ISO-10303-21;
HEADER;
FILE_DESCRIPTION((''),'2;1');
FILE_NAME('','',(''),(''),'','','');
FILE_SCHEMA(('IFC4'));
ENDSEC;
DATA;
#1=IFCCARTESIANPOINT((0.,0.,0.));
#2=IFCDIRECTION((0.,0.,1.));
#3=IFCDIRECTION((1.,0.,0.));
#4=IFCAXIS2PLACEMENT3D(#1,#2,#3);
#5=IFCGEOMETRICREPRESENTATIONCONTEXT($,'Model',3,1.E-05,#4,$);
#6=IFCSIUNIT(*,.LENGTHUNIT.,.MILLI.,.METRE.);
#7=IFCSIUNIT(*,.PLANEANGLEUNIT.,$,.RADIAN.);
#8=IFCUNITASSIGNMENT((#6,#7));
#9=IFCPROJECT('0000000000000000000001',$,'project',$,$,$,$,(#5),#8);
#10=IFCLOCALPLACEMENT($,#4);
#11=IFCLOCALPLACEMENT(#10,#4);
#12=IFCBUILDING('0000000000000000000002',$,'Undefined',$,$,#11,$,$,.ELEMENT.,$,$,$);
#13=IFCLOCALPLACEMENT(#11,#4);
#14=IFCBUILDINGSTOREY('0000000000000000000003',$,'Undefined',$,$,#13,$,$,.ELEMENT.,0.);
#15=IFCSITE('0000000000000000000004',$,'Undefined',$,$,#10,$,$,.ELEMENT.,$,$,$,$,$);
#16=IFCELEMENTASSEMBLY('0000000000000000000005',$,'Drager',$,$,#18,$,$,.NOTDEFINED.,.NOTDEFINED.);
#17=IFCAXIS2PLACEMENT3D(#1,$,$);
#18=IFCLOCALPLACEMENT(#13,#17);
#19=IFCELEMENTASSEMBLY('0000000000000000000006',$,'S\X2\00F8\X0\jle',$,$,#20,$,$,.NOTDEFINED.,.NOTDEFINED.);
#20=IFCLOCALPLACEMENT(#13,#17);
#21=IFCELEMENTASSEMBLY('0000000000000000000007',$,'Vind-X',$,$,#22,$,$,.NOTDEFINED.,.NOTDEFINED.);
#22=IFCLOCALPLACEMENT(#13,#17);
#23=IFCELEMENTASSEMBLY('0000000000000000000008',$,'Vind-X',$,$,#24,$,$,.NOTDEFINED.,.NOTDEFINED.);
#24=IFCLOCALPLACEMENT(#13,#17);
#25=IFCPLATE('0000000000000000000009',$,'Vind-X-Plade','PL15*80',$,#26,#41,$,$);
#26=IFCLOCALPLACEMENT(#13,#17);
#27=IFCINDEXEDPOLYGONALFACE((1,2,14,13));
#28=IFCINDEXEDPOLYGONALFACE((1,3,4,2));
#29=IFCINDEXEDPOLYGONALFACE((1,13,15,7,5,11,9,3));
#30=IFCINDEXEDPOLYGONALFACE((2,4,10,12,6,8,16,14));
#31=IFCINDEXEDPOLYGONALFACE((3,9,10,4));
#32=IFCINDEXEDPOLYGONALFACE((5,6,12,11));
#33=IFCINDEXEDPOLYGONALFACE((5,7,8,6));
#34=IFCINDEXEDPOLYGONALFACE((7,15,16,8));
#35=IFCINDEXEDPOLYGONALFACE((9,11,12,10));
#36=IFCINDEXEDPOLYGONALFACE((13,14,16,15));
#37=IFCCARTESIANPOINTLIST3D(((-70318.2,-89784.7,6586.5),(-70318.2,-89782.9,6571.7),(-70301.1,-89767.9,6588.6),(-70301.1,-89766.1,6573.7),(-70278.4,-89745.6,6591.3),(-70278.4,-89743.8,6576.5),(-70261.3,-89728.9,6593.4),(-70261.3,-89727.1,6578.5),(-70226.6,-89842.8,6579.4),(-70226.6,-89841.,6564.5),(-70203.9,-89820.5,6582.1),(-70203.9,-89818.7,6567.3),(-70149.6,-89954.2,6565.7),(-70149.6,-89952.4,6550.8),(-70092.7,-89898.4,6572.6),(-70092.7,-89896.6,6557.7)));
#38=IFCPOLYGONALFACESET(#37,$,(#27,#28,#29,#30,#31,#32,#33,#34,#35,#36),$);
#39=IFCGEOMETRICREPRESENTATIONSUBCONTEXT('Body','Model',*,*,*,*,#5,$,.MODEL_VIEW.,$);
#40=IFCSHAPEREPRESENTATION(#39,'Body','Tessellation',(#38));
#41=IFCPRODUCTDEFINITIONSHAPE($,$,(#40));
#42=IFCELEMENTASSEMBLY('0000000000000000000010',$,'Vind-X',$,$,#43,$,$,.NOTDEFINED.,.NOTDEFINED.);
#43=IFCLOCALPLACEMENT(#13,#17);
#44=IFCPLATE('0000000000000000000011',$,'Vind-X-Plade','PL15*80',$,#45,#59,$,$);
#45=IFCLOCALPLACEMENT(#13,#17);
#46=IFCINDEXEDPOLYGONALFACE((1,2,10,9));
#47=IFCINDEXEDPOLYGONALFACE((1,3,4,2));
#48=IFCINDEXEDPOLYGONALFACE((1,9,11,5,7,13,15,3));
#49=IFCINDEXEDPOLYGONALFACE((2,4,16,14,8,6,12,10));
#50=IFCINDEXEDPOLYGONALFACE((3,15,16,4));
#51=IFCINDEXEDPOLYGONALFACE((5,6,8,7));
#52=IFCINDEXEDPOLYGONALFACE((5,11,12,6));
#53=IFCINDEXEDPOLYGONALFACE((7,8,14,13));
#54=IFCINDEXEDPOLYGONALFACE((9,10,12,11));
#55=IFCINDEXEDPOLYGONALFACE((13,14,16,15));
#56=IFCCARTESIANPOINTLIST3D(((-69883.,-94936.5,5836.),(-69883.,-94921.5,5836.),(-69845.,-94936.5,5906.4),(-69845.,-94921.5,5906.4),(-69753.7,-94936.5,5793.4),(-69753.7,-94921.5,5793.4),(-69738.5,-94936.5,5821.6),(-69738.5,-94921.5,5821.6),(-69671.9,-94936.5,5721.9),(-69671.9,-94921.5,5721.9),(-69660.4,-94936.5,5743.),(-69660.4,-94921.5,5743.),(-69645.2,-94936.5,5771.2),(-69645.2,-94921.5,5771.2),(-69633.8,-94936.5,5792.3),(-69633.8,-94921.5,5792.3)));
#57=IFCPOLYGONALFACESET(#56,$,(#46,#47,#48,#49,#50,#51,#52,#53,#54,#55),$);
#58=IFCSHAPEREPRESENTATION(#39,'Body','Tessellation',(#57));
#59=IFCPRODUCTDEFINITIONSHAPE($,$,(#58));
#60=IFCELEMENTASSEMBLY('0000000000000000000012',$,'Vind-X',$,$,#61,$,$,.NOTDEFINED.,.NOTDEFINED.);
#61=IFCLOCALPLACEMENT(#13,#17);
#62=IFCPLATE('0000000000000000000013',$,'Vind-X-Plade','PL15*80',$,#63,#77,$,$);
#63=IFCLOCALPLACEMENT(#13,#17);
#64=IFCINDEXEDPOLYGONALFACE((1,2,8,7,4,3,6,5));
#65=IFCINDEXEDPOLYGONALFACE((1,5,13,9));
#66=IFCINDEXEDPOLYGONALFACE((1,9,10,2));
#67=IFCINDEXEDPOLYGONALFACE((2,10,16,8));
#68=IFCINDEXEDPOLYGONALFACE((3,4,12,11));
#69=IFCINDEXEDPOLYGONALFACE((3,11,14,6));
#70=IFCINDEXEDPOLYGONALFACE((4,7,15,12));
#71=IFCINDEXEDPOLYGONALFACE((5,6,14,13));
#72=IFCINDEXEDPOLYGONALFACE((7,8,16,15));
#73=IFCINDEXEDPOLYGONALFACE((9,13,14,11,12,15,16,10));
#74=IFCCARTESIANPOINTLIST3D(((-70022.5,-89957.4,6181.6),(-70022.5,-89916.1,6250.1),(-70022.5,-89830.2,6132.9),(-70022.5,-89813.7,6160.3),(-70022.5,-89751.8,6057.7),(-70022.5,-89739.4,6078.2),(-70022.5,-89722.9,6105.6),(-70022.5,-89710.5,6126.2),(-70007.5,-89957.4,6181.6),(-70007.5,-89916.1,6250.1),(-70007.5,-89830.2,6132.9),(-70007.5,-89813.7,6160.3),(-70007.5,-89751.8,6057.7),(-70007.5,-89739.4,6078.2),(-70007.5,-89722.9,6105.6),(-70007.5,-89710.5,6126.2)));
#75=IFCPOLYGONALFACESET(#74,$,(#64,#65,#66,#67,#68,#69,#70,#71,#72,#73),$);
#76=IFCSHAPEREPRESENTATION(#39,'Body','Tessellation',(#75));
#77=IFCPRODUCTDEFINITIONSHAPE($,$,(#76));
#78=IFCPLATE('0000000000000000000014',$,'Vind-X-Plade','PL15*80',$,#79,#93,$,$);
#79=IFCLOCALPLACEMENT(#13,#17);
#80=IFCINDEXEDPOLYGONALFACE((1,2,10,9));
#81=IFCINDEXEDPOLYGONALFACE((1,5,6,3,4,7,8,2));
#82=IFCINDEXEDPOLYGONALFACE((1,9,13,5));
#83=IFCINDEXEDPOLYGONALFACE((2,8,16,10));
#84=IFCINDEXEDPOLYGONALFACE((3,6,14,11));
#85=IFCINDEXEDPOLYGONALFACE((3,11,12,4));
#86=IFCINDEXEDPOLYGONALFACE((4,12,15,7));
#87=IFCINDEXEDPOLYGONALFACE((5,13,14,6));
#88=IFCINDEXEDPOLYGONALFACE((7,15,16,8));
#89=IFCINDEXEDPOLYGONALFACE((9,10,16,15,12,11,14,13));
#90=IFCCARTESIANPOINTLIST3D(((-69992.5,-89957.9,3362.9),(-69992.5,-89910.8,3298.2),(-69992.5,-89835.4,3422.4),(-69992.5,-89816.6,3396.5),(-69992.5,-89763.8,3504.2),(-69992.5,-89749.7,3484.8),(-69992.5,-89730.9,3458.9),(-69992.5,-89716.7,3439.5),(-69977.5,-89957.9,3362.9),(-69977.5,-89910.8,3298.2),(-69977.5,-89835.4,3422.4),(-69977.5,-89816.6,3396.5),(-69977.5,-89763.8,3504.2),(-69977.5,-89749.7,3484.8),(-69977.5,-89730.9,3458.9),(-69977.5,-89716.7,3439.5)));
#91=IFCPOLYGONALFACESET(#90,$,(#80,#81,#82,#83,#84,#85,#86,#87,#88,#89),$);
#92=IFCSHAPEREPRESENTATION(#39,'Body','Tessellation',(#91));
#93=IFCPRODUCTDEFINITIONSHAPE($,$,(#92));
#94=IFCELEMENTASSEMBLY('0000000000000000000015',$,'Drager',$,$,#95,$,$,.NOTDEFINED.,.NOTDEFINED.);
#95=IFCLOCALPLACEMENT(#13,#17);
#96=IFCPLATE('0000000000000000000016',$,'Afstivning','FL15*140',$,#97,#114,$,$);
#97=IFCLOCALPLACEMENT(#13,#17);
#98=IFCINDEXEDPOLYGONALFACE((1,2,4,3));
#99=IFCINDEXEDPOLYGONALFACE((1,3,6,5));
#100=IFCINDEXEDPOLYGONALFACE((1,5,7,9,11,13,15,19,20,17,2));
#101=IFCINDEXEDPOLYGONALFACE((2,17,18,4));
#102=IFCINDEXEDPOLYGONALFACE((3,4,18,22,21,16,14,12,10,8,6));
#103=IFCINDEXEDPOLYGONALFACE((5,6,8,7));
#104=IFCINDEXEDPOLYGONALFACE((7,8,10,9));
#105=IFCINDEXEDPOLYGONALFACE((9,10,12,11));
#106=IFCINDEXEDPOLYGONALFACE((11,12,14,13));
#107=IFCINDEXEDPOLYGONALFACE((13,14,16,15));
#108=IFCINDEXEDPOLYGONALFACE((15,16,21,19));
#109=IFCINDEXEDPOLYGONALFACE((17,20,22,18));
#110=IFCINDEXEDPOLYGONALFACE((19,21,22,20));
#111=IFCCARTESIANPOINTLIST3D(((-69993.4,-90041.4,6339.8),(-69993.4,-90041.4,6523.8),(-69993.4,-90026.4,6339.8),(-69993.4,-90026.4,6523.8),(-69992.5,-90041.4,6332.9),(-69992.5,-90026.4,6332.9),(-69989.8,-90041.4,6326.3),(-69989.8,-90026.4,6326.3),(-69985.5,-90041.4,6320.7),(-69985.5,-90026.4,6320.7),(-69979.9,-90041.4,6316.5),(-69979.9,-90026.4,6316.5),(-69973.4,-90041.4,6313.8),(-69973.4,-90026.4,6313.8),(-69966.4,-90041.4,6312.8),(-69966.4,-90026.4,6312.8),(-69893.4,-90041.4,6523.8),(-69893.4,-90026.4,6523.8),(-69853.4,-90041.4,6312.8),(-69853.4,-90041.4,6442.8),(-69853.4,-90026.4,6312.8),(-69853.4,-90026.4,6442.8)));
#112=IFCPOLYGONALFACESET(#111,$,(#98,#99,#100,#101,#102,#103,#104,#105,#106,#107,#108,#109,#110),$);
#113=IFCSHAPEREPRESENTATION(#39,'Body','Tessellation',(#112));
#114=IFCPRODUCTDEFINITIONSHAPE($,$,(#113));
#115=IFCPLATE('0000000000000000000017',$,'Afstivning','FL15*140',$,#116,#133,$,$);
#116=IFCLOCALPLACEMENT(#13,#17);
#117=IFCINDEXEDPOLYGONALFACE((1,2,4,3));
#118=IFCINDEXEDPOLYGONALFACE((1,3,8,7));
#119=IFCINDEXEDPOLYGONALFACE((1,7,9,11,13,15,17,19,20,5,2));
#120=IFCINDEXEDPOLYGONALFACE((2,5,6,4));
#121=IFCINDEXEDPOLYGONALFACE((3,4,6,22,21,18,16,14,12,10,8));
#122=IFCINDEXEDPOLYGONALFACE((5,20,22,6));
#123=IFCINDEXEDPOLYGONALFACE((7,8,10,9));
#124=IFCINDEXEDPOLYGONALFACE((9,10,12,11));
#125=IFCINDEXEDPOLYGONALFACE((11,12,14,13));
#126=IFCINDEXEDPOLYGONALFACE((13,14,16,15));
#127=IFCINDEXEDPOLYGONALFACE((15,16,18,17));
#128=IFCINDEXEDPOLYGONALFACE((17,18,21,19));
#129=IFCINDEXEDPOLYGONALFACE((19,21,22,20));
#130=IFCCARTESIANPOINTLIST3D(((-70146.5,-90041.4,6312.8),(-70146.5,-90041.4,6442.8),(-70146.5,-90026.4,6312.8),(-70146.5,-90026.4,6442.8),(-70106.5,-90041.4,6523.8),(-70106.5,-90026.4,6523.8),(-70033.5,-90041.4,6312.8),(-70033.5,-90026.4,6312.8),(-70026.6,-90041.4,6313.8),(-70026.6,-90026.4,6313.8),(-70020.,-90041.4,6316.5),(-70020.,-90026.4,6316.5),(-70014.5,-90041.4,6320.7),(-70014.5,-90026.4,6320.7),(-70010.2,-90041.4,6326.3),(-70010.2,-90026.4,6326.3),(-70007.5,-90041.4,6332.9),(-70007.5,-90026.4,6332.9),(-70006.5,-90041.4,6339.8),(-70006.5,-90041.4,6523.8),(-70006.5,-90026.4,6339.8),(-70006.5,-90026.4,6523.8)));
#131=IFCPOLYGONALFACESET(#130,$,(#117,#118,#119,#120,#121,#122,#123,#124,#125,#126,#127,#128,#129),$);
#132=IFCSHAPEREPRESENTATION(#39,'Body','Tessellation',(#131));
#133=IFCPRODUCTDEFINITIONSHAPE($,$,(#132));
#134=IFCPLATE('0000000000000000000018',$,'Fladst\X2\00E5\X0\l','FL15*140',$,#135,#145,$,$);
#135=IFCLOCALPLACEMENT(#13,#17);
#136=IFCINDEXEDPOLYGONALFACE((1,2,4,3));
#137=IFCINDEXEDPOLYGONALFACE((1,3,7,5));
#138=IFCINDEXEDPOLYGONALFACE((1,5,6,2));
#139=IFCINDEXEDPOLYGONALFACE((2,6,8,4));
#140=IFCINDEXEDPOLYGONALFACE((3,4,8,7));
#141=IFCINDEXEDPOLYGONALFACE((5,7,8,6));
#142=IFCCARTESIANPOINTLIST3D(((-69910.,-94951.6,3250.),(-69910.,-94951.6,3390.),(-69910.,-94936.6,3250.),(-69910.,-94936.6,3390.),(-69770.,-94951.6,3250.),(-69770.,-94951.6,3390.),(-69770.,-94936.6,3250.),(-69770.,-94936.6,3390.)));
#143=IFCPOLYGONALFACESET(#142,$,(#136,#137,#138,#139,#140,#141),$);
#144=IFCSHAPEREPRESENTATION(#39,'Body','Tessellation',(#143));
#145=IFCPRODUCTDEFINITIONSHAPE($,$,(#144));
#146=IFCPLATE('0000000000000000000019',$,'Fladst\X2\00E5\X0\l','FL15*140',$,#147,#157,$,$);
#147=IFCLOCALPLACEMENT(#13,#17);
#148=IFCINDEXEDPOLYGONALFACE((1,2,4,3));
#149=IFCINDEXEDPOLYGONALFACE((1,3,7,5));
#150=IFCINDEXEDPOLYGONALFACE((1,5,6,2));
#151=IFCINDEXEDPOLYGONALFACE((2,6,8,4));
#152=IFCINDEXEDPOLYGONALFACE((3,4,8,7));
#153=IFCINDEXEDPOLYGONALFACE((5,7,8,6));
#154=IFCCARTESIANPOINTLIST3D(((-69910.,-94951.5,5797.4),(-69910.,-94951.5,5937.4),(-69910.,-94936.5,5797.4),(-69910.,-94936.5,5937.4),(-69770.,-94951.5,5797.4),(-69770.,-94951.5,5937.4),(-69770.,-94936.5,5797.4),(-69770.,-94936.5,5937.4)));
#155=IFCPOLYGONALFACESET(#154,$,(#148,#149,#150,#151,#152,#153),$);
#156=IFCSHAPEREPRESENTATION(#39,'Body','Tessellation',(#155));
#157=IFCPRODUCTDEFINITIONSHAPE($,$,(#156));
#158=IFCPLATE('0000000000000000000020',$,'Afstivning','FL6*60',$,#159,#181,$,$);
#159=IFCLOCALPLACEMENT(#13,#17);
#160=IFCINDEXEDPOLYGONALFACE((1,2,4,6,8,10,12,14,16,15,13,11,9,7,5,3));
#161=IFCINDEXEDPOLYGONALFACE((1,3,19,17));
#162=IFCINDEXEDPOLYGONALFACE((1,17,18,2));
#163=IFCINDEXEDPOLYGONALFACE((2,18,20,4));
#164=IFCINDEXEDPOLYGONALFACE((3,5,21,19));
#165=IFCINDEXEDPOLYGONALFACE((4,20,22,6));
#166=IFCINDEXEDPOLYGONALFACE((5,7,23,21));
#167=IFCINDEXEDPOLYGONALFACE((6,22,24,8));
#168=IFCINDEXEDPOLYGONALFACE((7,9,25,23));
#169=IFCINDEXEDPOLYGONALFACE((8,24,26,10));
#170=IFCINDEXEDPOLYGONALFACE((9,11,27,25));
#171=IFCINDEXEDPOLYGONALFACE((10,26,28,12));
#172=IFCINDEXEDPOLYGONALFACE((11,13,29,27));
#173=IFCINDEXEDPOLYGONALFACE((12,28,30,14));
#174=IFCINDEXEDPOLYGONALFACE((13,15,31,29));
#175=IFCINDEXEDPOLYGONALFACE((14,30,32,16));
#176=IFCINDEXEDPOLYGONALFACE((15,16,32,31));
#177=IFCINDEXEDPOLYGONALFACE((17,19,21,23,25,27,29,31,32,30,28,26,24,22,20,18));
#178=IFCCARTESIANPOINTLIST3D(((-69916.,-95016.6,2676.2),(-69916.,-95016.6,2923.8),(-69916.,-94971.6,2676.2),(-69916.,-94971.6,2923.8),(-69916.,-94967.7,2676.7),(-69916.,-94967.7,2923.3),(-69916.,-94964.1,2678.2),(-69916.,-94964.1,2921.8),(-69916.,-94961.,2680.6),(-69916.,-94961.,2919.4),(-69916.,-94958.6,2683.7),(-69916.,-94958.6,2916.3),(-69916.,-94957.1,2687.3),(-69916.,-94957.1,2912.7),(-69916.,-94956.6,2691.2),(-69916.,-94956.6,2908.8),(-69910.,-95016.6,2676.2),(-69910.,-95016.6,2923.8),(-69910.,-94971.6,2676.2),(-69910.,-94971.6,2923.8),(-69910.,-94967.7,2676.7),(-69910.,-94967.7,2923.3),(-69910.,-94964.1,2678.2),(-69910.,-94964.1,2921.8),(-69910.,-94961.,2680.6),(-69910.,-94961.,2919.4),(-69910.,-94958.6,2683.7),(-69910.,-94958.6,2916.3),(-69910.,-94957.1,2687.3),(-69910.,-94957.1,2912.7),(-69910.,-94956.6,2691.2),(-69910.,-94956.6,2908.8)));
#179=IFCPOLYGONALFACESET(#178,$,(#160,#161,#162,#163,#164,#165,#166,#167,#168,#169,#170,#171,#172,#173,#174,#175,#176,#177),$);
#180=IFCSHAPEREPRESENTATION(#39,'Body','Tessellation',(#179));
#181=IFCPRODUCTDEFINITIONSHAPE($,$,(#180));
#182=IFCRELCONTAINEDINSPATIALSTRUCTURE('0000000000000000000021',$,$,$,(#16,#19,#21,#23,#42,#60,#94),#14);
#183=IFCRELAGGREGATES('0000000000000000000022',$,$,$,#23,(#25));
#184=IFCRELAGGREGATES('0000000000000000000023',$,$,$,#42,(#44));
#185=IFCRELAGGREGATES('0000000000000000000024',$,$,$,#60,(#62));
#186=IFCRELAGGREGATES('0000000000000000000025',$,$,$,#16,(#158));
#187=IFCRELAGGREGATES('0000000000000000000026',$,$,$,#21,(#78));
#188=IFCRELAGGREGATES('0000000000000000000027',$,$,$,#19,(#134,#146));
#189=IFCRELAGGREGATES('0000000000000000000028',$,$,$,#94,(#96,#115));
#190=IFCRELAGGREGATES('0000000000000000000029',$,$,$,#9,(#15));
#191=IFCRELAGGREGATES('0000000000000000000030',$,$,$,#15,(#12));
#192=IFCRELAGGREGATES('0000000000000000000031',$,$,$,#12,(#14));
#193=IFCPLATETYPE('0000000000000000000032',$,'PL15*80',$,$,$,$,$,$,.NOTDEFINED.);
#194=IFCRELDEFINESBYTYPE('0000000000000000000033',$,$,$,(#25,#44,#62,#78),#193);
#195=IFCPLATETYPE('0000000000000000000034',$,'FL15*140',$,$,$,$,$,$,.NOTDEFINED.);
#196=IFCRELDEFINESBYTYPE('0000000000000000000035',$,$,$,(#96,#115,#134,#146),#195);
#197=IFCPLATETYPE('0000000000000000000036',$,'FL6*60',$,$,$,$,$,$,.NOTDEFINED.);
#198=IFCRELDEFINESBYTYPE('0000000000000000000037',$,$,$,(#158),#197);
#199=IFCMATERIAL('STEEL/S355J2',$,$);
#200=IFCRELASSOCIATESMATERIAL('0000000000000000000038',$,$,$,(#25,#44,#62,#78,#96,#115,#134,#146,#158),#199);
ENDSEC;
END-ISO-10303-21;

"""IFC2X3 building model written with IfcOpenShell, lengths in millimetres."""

from ifc_helpers import new_model, si_unit, frame, frame_2d, origin_with_axes, place, context, subcontext, project, spatial, polyline, circle_curve, parameter, trimmed, segment, composite_curve, outline, extrude, boolean, material, type_object, element, aggregate, save


model = new_model("IFC2X3")

# Units and contexts
model_context = context("Model", 3, precision=1e-05, world=origin_with_axes())
body_context = subcontext(model_context, "Body", "Model", "MODEL_VIEW")
ifc_project = project(units=[si_unit("LENGTHUNIT", "METRE", prefix="MILLI"), si_unit("PLANEANGLEUNIT", "RADIAN")], contexts=[model_context])

# Site, building, storey
site_placement = place(None, origin_with_axes())
site = spatial("IfcSite", under=ifc_project, at=site_placement, Name="Undefined", CompositionType="ELEMENT")
building_placement = place(site_placement, origin_with_axes())
building = spatial("IfcBuilding", under=site, at=building_placement, Name="Undefined", CompositionType="ELEMENT")
storey_placement = place(building_placement, origin_with_axes())
storey = spatial("IfcBuildingStorey", under=building, at=storey_placement, Name="Undefined", CompositionType="ELEMENT", Elevation=0.0)

# Element assemblies
assembly_1_placement = place(storey_placement, origin_with_axes())
assembly_1 = element("IfcElementAssembly", 1, at=assembly_1_placement, inside=storey, Name="Drager", AssemblyPlace="NOTDEFINED", PredefinedType="NOTDEFINED")
assembly_2_placement = place(storey_placement, origin_with_axes())
assembly_2 = element("IfcElementAssembly", 2, at=assembly_2_placement, inside=storey, Name="Søjle", AssemblyPlace="NOTDEFINED", PredefinedType="NOTDEFINED")

# Element assembly
assembly_3_placement = place(storey_placement, origin_with_axes())
assembly_3 = element("IfcElementAssembly", 3, at=assembly_3_placement, inside=storey, Name="Vind-X", AssemblyPlace="NOTDEFINED", PredefinedType="NOTDEFINED")
ifc_material_1 = material(Name="STEEL/S355J2")

# Element assemblies, plates
plate_type_1 = type_object("IfcPlateType", Name="PL15*80", PredefinedType="NOTDEFINED")
assembly_4_placement = place(storey_placement, origin_with_axes())
assembly_4 = element("IfcElementAssembly", 4, at=assembly_4_placement, inside=storey, Name="Vind-X", AssemblyPlace="NOTDEFINED", PredefinedType="NOTDEFINED")
plate_1_placement = place(assembly_4_placement, frame((-70149.6, -89953.3, 6558.3), z_axis=(0.0, -0.121869, 0.992546), x_axis=(0.711592, 0.697356, 0.085625)))
plate_1 = element("IfcPlate", 5, at=plate_1_placement, type_object=plate_type_1, material=ifc_material_1, Name="Vind-X-Plade", Description="PL15*80", context=body_context, shape_type="CSG", body=[
    boolean("DIFFERENCE", extrude(outline(polyline([(0.0, 0.0), (80.0, 0.0), (80.0, 240.0), (0.0, 240.0), (0.0, 0.0)])), frame((0.0, 0.0, -7.5), z_axis=(0.0, 0.0, 1.0), x_axis=(1.0, 0.0, 0.0)), (0.0, 0.0, 1.0), 15.0), extrude(outline(polyline([(0.0, 0.0), (106.0, 0.0), (106.0, 32.0), (0.0, 32.0), (0.0, 0.0)])), frame((56.0, 240.0, 8.5), z_axis=(0.0, 0.0, -1.0), x_axis=(0.0, -1.0, 0.0)), (0.0, 0.0, 1.0), 17.0)),
])
aggregate(assembly_4, [plate_1])
assembly_5_placement = place(storey_placement, origin_with_axes())
assembly_5 = element("IfcElementAssembly", 6, at=assembly_5_placement, inside=storey, Name="Vind-X", AssemblyPlace="NOTDEFINED", PredefinedType="NOTDEFINED")
plate_2_placement = place(assembly_5_placement, frame((-69883.0, -94929.0, 5836.0), z_axis=(0.0, 1.0, 0.0), x_axis=(0.475416, 0.0, 0.879761)))
plate_2 = element("IfcPlate", 7, at=plate_2_placement, type_object=plate_type_1, material=ifc_material_1, Name="Vind-X-Plade", Description="PL15*80", context=body_context, shape_type="CSG", body=[
    boolean("DIFFERENCE", extrude(outline(polyline([(0.0, 0.0), (80.0, 0.0), (80.0, 240.0), (0.0, 240.0), (0.0, 0.0)])), frame((0.0, 0.0, -7.5), z_axis=(0.0, 0.0, 1.0), x_axis=(1.0, 0.0, 0.0)), (0.0, 0.0, 1.0), 15.0), extrude(outline(polyline([(0.0, 0.0), (106.0, 0.0), (106.0, 32.0), (0.0, 32.0), (0.0, 0.0)])), frame((56.0, 240.0, 8.5), z_axis=(0.0, 0.0, -1.0), x_axis=(0.0, -1.0, 0.0)), (0.0, 0.0, 1.0), 17.0)),
])
aggregate(assembly_5, [plate_2])
assembly_6_placement = place(storey_placement, origin_with_axes())
assembly_6 = element("IfcElementAssembly", 8, at=assembly_6_placement, inside=storey, Name="Vind-X", AssemblyPlace="NOTDEFINED", PredefinedType="NOTDEFINED")
plate_3_placement = place(assembly_6_placement, frame((-70015.0, -89957.4, 6181.6), z_axis=(-1.0, 0.0, 0.0), x_axis=(0.0, 0.516238, 0.856445)))
plate_3 = element("IfcPlate", 9, at=plate_3_placement, type_object=plate_type_1, material=ifc_material_1, Name="Vind-X-Plade", Description="PL15*80", context=body_context, shape_type="CSG", body=[
    boolean("DIFFERENCE", extrude(outline(polyline([(0.0, 0.0), (80.0, 0.0), (80.0, 240.0), (0.0, 240.0), (0.0, 0.0)])), frame((0.0, 0.0, -7.5), z_axis=(0.0, 0.0, 1.0), x_axis=(1.0, 0.0, 0.0)), (0.0, 0.0, 1.0), 15.0), extrude(outline(polyline([(0.0, 0.0), (106.0, 0.0), (106.0, 32.0), (0.0, 32.0), (0.0, 0.0)])), frame((56.0, 240.0, 8.5), z_axis=(0.0, 0.0, -1.0), x_axis=(0.000011, -1.0, 0.0)), (0.0, 0.0, 1.0), 17.0)),
])
aggregate(assembly_6, [plate_3])

# Plate
plate_4_placement = place(assembly_3_placement, frame((-69985.0, -89910.8, 3298.2), z_axis=(-1.0, 0.0, 0.0), x_axis=(0.0, -0.588607, 0.80842)))
plate_4 = element("IfcPlate", 10, at=plate_4_placement, type_object=plate_type_1, material=ifc_material_1, Name="Vind-X-Plade", Description="PL15*80", context=body_context, shape_type="CSG", body=[
    boolean("DIFFERENCE", extrude(outline(polyline([(0.0, 0.0), (80.0, 0.0), (80.0, 240.0), (0.0, 240.0), (0.0, 0.0)])), frame((0.0, 0.0, -7.5), z_axis=(0.0, 0.0, 1.0), x_axis=(1.0, 0.0, 0.0)), (0.0, 0.0, 1.0), 15.0), extrude(outline(polyline([(0.0, 0.0), (106.0, 0.0), (106.0, 32.0), (0.0, 32.0), (0.0, 0.0)])), frame((56.0, 240.0, 8.5), z_axis=(0.0, 0.0, -1.0), x_axis=(-0.00001, -1.0, 0.0)), (0.0, 0.0, 1.0), 17.0)),
])

# Element assembly, plates
assembly_7_placement = place(storey_placement, origin_with_axes())
assembly_7 = element("IfcElementAssembly", 11, at=assembly_7_placement, inside=storey, Name="Drager", AssemblyPlace="NOTDEFINED", PredefinedType="NOTDEFINED")
plate_type_2 = type_object("IfcPlateType", Name="FL15*140", PredefinedType="NOTDEFINED")
plate_5_placement = place(assembly_7_placement, frame((-69993.4, -90033.9, 6312.8), z_axis=(0.0, -1.0, 0.0), x_axis=(1.0, 0.0, 0.0)))
plate_5 = element("IfcPlate", 12, at=plate_5_placement, type_object=plate_type_2, material=ifc_material_1, Name="Afstivning", Description="FL15*140", context=body_context, shape_type="SweptSolid", body=[
    extrude(outline(composite_curve([segment(trimmed(circle_curve(frame_2d((27.0, 27.0), x_axis=(-1.0, 0.0)), 27.0), [parameter(0.0)], [parameter(1.570796)], True, "PARAMETER"), True, "CONTINUOUS"), segment(polyline([(27.0, 0.0), (140.0, 0.0), (140.0, 130.0), (100.0, 211.0), (0.0, 211.0), (0.0, 27.0)]), True, "CONTINUOUS")], self_intersect=True)), frame((0.0, 0.0, -7.5), z_axis=(0.0, 0.0, 1.0), x_axis=(1.0, 0.0, 0.0)), (0.0, 0.0, 1.0), 15.0),
])
plate_6_placement = place(assembly_7_placement, frame((-70146.5, -90033.9, 6312.8), z_axis=(0.0, -1.0, 0.0), x_axis=(1.0, 0.0, 0.0)))
plate_6 = element("IfcPlate", 13, at=plate_6_placement, type_object=plate_type_2, material=ifc_material_1, Name="Afstivning", Description="FL15*140", context=body_context, shape_type="SweptSolid", body=[
    extrude(outline(composite_curve([segment(polyline([(0.0, 0.0), (113.0, 0.0)]), True, "CONTINUOUS"), segment(trimmed(circle_curve(frame_2d((113.0, 27.0), x_axis=(0.0, -1.0)), 27.0), [parameter(0.0)], [parameter(1.570796)], True, "PARAMETER"), True, "CONTINUOUS"), segment(polyline([(140.0, 27.0), (140.0, 211.0), (40.0, 211.0), (0.0, 130.0), (0.0, 0.0)]), True, "CONTINUOUS")], self_intersect=True)), frame((0.0, 0.0, -7.5), z_axis=(0.0, 0.0, 1.0), x_axis=(1.0, 0.0, 0.0)), (0.0, 0.0, 1.0), 15.0),
])

# Plates
plate_7_placement = place(assembly_2_placement, frame((-69910.0, -94944.1, 3250.0), z_axis=(0.0, -1.0, 0.0), x_axis=(1.0, 0.0, 0.0)))
plate_7 = element("IfcPlate", 14, at=plate_7_placement, type_object=plate_type_2, material=ifc_material_1, Name="Fladstål", Description="FL15*140", context=body_context, shape_type="SweptSolid", body=[
    extrude(outline(polyline([(0.0, 0.0), (140.0, 0.0), (140.0, 140.0), (0.0, 140.0), (0.0, 0.0)])), frame((0.0, 0.0, -7.5), z_axis=(0.0, 0.0, 1.0), x_axis=(1.0, 0.0, 0.0)), (0.0, 0.0, 1.0), 15.0),
])
plate_8_placement = place(assembly_2_placement, frame((-69910.0, -94944.0, 5797.4), z_axis=(0.0, -1.0, 0.0), x_axis=(1.0, 0.0, 0.0)))
plate_8 = element("IfcPlate", 15, at=plate_8_placement, type_object=plate_type_2, material=ifc_material_1, Name="Fladstål", Description="FL15*140", context=body_context, shape_type="SweptSolid", body=[
    extrude(outline(polyline([(0.0, 0.0), (140.0, 0.0), (140.0, 140.0), (0.0, 140.0), (0.0, 0.0)])), frame((0.0, 0.0, -7.5), z_axis=(0.0, 0.0, 1.0), x_axis=(1.0, 0.0, 0.0)), (0.0, 0.0, 1.0), 15.0),
])
plate_type_3 = type_object("IfcPlateType", Name="FL6*60", PredefinedType="NOTDEFINED")
plate_9_placement = place(assembly_1_placement, frame((-69913.0, -94956.6, 2923.8), z_axis=(1.0, 0.0, 0.0), x_axis=(0.0, -1.0, 0.0)))
plate_9 = element("IfcPlate", 16, at=plate_9_placement, type_object=plate_type_3, material=ifc_material_1, Name="Afstivning", Description="FL6*60", context=body_context, shape_type="SweptSolid", body=[
    extrude(outline(composite_curve([segment(trimmed(circle_curve(frame_2d((15.0, 15.0), x_axis=(-1.0, 0.0)), 15.0), [parameter(0.0)], [parameter(1.570796)], True, "PARAMETER"), True, "CONTINUOUS"), segment(polyline([(15.0, 0.0), (60.0, 0.0), (60.0, 247.6), (15.0, 247.6)]), True, "CONTINUOUS"), segment(trimmed(circle_curve(frame_2d((15.0, 232.6), x_axis=(0.0, 1.0)), 15.0), [parameter(0.0)], [parameter(1.570796)], True, "PARAMETER"), True, "CONTINUOUS"), segment(polyline([(0.0, 232.6), (0.0, 15.0)]), True, "CONTINUOUS")], self_intersect=True)), frame((0.0, 0.0, -3.0), z_axis=(0.0, 0.0, 1.0), x_axis=(1.0, 0.0, 0.0)), (0.0, 0.0, 1.0), 6.0),
])
aggregate(assembly_1, [plate_9])

aggregate(assembly_3, [plate_4])
aggregate(assembly_2, [plate_7, plate_8])
aggregate(assembly_7, [plate_5, plate_6])

save(model, "model.ifc")
